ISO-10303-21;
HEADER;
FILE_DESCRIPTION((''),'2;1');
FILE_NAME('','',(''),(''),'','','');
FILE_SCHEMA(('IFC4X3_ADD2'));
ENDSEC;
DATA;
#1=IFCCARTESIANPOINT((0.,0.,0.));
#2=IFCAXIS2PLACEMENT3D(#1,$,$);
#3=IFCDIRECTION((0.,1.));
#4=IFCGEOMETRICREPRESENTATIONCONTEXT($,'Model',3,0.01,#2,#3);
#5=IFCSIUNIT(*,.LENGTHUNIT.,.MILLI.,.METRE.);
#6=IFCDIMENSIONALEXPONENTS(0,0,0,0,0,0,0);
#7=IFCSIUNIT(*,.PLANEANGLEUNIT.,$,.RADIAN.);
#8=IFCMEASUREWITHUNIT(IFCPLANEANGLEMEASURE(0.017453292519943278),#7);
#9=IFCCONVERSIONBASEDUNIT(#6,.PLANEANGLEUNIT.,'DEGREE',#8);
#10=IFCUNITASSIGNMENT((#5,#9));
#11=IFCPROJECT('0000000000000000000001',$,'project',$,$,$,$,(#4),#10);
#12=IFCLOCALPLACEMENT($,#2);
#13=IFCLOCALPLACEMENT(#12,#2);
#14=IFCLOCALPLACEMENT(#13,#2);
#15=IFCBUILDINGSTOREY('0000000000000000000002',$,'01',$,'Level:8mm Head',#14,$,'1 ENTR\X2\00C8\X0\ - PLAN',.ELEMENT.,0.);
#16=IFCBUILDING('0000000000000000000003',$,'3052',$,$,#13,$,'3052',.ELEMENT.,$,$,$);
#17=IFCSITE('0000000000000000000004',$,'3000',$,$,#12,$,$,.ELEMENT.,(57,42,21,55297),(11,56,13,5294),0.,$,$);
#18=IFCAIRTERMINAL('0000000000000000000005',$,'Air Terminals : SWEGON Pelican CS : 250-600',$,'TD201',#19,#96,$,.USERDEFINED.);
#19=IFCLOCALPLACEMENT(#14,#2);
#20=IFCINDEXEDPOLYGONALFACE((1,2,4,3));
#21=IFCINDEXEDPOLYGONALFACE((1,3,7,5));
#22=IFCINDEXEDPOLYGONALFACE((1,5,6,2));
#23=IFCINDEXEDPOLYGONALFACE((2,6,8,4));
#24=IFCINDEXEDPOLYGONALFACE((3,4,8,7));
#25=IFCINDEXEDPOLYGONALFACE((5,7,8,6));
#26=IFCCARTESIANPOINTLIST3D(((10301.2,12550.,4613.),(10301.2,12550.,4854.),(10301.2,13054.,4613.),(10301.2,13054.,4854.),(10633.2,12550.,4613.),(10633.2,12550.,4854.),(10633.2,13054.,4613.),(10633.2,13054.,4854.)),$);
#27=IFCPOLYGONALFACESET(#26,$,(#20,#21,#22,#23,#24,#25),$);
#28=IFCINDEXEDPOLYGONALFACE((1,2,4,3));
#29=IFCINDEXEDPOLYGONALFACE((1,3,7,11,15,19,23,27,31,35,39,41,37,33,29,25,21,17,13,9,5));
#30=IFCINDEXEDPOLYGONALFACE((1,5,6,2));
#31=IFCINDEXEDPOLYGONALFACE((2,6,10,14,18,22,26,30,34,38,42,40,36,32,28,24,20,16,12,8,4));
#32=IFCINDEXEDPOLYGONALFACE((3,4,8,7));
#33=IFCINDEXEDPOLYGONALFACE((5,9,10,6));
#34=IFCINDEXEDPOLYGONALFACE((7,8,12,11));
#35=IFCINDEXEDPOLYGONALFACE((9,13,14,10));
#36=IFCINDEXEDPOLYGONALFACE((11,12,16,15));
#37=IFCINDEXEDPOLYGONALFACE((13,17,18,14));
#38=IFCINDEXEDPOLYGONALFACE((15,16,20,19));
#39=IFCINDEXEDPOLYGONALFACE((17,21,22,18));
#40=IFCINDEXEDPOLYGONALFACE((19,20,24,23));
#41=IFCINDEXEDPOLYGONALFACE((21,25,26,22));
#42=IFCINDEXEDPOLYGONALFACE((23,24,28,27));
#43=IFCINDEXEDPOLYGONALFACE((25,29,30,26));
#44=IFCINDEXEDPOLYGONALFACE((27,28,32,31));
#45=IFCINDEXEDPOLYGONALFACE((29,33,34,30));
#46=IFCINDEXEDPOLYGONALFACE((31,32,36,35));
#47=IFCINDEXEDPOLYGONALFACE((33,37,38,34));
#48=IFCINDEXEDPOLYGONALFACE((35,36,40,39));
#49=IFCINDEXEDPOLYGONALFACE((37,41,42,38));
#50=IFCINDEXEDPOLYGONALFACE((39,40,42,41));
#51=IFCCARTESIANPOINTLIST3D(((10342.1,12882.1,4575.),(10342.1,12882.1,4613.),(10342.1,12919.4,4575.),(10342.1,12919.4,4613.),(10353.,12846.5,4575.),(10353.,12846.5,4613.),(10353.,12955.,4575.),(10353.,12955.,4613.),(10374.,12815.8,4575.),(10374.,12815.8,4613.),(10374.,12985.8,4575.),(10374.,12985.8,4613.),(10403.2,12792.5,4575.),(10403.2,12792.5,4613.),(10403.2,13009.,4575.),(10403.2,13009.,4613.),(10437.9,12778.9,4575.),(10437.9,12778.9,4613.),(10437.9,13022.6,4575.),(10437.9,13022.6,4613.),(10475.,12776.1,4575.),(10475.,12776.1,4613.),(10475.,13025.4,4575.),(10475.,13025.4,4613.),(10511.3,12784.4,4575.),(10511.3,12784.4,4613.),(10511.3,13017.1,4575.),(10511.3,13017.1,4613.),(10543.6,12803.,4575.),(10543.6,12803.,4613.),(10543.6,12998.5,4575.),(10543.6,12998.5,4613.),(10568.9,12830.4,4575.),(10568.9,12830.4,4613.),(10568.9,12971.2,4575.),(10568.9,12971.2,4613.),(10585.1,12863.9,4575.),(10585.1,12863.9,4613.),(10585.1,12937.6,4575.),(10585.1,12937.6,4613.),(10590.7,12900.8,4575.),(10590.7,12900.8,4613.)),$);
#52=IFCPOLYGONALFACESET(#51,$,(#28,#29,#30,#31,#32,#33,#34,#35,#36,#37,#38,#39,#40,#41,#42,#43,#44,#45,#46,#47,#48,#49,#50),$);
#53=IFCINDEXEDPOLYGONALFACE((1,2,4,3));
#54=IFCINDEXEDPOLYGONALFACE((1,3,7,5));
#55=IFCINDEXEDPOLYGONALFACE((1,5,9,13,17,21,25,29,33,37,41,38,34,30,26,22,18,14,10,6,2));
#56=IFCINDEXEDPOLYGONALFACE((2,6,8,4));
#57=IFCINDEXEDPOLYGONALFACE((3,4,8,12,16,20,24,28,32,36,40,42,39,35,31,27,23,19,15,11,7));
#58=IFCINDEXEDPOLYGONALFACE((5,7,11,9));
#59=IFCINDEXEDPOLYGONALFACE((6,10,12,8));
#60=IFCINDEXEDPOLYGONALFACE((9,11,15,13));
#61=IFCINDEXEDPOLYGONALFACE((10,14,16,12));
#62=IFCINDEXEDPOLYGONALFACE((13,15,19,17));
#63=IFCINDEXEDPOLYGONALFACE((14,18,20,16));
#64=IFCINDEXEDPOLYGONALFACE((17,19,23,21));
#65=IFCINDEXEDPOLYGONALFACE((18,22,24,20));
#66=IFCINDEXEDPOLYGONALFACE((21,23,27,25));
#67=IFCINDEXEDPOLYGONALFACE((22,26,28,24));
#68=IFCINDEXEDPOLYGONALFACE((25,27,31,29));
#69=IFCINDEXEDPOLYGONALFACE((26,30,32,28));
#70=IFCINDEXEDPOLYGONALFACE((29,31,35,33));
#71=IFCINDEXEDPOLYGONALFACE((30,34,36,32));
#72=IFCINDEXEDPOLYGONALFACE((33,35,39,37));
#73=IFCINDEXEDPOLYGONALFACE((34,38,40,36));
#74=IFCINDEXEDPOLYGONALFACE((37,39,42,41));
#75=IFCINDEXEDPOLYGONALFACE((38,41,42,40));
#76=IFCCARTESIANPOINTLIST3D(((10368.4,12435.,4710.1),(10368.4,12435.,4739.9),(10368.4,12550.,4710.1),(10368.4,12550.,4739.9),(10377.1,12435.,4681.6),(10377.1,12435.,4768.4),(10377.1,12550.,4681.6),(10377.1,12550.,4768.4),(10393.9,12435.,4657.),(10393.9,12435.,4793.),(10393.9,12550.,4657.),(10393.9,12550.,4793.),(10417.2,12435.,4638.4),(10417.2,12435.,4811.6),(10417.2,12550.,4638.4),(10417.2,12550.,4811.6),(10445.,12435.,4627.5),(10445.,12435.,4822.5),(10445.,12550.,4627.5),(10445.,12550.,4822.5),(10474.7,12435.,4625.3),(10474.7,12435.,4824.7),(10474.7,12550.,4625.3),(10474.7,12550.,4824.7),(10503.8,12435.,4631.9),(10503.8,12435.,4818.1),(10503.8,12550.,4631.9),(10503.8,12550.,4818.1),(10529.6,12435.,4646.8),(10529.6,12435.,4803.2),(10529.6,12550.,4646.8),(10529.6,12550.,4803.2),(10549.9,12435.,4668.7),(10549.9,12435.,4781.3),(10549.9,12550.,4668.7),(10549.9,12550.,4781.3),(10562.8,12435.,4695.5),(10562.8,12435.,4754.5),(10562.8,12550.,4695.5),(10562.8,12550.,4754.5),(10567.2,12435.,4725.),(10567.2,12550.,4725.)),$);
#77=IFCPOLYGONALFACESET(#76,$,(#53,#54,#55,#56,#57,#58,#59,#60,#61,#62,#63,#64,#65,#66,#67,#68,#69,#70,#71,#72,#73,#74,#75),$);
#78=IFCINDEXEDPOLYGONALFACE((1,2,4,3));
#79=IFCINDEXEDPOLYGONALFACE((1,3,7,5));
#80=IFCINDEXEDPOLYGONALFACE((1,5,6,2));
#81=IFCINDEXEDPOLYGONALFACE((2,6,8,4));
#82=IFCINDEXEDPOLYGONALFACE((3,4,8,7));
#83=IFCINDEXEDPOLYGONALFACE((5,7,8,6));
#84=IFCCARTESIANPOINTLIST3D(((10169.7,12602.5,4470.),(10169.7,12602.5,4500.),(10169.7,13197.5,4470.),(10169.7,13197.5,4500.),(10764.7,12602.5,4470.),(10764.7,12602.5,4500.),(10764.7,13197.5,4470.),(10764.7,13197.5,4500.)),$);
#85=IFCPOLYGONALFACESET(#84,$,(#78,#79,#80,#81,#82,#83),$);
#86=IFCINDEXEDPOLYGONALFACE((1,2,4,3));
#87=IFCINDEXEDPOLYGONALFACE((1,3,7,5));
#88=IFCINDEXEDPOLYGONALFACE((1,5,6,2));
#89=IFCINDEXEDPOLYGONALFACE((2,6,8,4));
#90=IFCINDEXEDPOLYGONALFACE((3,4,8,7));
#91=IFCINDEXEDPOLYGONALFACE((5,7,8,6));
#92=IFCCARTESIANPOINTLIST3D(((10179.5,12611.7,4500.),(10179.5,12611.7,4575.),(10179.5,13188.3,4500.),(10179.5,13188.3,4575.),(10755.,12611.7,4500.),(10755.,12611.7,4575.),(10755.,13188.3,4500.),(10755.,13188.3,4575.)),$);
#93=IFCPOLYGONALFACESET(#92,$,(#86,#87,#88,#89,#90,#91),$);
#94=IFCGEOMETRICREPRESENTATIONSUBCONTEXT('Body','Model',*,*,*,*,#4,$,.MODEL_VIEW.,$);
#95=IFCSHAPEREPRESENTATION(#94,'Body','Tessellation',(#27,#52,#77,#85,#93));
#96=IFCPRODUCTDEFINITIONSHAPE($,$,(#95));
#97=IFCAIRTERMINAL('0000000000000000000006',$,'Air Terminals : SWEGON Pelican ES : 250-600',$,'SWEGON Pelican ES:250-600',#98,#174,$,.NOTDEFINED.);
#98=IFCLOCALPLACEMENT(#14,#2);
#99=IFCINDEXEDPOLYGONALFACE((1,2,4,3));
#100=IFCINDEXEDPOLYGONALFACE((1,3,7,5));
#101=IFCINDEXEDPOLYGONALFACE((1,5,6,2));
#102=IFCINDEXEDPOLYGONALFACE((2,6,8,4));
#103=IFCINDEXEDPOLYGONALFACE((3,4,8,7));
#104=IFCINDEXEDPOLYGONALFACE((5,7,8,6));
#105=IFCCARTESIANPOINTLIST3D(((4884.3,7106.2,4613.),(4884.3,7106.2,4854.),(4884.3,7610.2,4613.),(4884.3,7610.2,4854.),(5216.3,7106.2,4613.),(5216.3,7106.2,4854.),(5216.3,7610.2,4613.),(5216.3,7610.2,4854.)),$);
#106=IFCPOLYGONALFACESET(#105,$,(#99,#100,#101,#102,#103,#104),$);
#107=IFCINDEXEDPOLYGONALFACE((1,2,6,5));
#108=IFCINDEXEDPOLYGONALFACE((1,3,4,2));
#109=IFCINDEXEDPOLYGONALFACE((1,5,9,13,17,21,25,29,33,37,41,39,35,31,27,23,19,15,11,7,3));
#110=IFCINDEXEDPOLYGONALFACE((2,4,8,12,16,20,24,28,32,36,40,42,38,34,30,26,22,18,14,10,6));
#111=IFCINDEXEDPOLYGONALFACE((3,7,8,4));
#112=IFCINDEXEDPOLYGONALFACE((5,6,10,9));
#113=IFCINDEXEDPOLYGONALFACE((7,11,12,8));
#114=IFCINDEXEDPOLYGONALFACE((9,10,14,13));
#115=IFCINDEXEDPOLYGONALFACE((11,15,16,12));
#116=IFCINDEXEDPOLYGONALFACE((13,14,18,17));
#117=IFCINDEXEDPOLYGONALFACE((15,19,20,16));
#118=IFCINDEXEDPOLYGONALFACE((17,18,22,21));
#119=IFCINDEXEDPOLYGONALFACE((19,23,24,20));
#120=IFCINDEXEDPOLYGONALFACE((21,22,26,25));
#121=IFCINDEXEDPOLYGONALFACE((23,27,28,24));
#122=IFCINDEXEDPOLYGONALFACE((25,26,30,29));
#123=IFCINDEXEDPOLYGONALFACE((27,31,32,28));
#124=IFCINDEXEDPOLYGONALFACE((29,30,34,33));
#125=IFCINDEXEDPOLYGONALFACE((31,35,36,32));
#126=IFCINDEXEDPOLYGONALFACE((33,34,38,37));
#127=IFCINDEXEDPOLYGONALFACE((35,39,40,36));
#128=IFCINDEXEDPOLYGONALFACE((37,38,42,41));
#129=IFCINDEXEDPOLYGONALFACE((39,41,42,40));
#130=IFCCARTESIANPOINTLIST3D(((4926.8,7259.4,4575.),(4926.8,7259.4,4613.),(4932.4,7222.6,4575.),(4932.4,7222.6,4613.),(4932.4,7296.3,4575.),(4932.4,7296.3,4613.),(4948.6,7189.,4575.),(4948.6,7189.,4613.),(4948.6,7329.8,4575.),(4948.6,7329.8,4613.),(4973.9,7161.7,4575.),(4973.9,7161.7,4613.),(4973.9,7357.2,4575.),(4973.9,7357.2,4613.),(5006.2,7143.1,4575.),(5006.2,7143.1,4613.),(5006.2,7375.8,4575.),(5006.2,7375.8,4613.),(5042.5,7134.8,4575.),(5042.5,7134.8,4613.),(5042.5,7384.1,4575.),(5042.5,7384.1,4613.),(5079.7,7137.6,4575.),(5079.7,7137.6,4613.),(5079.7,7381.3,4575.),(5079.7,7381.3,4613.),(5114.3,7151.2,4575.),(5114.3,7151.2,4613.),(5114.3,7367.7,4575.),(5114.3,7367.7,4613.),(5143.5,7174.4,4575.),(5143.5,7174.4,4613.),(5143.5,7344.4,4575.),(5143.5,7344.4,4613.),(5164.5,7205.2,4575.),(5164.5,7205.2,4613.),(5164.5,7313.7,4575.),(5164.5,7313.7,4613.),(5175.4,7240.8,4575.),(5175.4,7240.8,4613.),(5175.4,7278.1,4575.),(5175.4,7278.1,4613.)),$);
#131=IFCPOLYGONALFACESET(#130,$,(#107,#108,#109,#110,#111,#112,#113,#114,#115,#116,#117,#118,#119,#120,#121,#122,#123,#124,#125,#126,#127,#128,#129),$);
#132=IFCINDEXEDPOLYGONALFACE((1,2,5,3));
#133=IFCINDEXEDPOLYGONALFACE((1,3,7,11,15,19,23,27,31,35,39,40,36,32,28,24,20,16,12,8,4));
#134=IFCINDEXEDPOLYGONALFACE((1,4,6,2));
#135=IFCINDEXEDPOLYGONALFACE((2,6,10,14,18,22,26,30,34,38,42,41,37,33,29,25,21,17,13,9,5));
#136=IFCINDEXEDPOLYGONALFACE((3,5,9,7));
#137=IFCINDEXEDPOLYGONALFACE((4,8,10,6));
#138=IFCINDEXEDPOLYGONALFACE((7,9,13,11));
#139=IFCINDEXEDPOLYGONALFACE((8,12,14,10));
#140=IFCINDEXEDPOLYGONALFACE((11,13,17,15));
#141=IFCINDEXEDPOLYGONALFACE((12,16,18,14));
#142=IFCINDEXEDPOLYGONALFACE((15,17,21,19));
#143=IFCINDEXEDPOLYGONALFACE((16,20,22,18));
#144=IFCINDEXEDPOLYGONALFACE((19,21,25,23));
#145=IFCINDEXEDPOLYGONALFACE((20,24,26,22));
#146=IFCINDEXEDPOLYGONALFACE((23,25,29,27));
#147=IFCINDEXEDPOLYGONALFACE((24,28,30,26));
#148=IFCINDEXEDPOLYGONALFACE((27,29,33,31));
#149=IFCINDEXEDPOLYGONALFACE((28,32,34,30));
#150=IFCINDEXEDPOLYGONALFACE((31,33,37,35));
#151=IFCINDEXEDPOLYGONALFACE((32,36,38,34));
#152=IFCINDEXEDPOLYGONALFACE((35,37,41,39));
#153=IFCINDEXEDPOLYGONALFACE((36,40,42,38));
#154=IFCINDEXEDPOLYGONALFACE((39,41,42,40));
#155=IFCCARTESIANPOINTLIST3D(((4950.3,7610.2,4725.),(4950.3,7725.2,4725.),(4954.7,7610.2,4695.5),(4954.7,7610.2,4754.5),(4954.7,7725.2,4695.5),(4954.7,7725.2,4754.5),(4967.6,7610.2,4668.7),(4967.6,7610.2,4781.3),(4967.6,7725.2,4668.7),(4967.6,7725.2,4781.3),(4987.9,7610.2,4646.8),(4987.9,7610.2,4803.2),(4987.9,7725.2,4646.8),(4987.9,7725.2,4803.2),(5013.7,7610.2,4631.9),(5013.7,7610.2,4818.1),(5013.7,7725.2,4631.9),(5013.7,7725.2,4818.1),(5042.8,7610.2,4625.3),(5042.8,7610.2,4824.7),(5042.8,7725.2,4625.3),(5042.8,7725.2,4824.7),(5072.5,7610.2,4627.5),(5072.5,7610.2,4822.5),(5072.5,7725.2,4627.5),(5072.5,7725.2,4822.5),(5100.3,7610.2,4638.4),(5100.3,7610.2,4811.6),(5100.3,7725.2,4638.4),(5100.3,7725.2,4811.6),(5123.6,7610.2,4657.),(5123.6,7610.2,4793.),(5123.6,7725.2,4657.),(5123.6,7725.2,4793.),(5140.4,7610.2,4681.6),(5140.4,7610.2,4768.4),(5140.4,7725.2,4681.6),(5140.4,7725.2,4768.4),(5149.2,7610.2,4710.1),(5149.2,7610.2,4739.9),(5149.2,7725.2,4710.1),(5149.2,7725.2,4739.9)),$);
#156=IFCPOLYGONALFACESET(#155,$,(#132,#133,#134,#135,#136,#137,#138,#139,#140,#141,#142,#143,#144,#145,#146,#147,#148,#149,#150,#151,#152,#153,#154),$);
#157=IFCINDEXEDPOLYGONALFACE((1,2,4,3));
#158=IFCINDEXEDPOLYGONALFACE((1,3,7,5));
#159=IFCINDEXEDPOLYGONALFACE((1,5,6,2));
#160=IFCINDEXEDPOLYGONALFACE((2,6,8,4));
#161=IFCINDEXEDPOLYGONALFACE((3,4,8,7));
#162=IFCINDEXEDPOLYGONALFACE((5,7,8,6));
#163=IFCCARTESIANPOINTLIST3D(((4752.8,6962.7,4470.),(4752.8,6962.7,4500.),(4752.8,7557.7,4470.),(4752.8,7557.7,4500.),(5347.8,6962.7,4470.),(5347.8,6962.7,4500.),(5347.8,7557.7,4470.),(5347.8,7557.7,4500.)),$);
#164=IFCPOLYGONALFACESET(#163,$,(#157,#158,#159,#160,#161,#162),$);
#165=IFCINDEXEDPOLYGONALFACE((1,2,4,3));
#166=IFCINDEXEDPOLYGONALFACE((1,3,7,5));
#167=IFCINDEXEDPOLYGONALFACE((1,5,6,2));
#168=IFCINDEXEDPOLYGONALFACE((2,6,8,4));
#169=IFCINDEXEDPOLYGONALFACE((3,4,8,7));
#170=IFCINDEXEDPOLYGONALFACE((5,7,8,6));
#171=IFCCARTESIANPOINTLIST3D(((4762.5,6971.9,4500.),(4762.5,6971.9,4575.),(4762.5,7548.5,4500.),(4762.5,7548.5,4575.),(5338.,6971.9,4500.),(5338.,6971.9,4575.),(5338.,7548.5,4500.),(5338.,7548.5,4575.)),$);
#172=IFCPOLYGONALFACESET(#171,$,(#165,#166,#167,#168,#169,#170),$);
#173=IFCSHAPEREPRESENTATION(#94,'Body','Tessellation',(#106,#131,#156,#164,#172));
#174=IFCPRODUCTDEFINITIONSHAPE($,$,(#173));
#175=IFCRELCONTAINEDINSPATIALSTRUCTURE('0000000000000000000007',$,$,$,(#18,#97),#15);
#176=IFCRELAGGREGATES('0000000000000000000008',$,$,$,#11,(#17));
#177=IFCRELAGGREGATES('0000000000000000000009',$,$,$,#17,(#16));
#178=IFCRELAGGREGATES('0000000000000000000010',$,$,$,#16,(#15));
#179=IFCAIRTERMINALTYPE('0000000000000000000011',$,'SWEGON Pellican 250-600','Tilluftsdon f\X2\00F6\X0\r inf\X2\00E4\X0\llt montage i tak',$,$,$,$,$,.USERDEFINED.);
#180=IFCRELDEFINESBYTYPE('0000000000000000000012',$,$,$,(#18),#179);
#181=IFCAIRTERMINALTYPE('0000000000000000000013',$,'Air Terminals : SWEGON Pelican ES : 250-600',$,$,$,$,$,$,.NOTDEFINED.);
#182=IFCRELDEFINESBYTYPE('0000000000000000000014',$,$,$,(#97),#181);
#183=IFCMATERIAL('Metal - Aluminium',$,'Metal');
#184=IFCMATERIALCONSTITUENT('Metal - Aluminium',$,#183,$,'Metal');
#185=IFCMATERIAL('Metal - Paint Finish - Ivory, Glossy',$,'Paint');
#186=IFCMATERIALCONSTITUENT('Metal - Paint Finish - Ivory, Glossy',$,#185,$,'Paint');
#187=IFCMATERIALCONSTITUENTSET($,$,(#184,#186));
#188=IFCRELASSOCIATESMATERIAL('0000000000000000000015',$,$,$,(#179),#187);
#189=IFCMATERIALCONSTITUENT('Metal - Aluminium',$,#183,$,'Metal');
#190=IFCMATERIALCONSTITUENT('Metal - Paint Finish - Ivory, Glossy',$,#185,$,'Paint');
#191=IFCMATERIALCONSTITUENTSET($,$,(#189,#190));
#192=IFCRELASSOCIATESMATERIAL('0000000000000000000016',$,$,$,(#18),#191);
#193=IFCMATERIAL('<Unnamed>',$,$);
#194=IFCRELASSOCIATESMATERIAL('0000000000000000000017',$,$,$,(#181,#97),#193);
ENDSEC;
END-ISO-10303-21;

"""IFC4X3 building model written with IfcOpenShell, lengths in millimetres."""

from ifc_helpers import new_model, entity, si_unit, converted_unit, direction, frame, frame_2d, origin, origin_2d_with_axis, place, context, subcontext, project, spatial, rectangle, circle, extrude, source, transform, mapped, material, constituent, constituent_set, type_object, type_shapes, element, save


model = new_model("IFC4X3")

# Units and contexts
model_context = context("Model", 3, precision=0.01, world=origin(), true_north=direction((0.0, 1.0)))
body_context = subcontext(model_context, "Body", "Model", "MODEL_VIEW")
ifc_project = project(units=[si_unit("LENGTHUNIT", "METRE", prefix="MILLI"), converted_unit("PLANEANGLEUNIT", "DEGREE", entity("IfcPlaneAngleMeasure", 0.017453292519943278), si_unit("PLANEANGLEUNIT", "RADIAN"), dimensions=[0, 0, 0, 0, 0, 0, 0])], contexts=[model_context])

# Site, building, storey
site_placement = place(None, origin())
site = spatial("IfcSite", under=ifc_project, at=site_placement, Name="3000", CompositionType="ELEMENT", RefLatitude=(57, 42, 21, 55297), RefLongitude=(11, 56, 13, 5294), RefElevation=0.0)
building_placement = place(site_placement, origin())
building = spatial("IfcBuilding", under=site, at=building_placement, Name="3052", LongName="3052", CompositionType="ELEMENT")
storey_placement = place(building_placement, origin())
storey = spatial("IfcBuildingStorey", under=building, at=storey_placement, Name="01", ObjectType="Level:8mm Head", LongName="1 ENTRÈ - PLAN", CompositionType="ELEMENT", Elevation=0.0)

# Shared definitions
ifc_material_1 = material(Name="<Unnamed>")

# Air terminals
ifc_material_2 = material(Name="Metal - Aluminium", Category="Metal")
ifc_constituent_1 = constituent(ifc_material_2, Name="Metal - Aluminium", Category="Metal")
ifc_material_3 = material(Name="Metal - Paint Finish - Ivory, Glossy", Category="Paint")
ifc_constituent_2 = constituent(ifc_material_3, Name="Metal - Paint Finish - Ivory, Glossy", Category="Paint")
ifc_constituent_set_1 = constituent_set(constituents=[ifc_constituent_1, ifc_constituent_2])
ifc_constituent_3 = constituent(ifc_material_2, Name="Metal - Aluminium", Category="Metal")
ifc_constituent_4 = constituent(ifc_material_3, Name="Metal - Paint Finish - Ivory, Glossy", Category="Paint")
ifc_constituent_set_2 = constituent_set(constituents=[ifc_constituent_3, ifc_constituent_4])
air_terminal_type_1 = type_object("IfcAirTerminalType", Name="SWEGON Pellican 250-600", Description="Tilluftsdon för infällt montage i tak", PredefinedType="USERDEFINED", material=ifc_constituent_set_2)
shared_shape_1 = source(origin(), body_context, "Body", "SweptSolid", [
    extrude(rectangle(XDim=332.0, YDim=504.0, at=origin_2d_with_axis()), frame((0.0, 98.0, -354.0), z_axis=(0.0, 0.0, 1.0), x_axis=(-1.0, 0.0, 0.0)), (0.0, 0.0, 1.0), 241.0),
    extrude(circle(Radius=125.0, at=frame_2d((0.0, 0.0), x_axis=(1.0, 0.0))), frame((-1.6, -0.8, -113.0)), (0.0, 0.0, 1.0), 38.0),
    extrude(circle(Radius=100.0, at=frame_2d((0.0, 0.0), x_axis=(1.0, 0.0))), frame((0.0, 350.0, -225.0), z_axis=(0.0, 1.0, 0.0), x_axis=(1.0, 0.0, 0.0)), (0.0, 0.0, 1.0), 115.0),
    extrude(rectangle(XDim=595.0, YDim=595.0, at=frame_2d((0.0, 0.0), x_axis=(1.0, 0.0))), frame((0.0, 0.0, 0.0), z_axis=(0.0, 0.0, 1.0), x_axis=(-1.0, 0.0, 0.0)), (0.0, 0.0, 1.0), 30.0),
    extrude(rectangle(XDim=575.5, YDim=576.5, at=origin_2d_with_axis()), frame((0.0, 0.0, -75.0), z_axis=(0.0, 0.0, 1.0), x_axis=(-1.0, 0.0, 0.0)), (0.0, 0.0, 1.0), 75.0),
])
type_shapes(air_terminal_type_1, [shared_shape_1])
air_terminal_1_placement = place(storey_placement, frame((10467.2, 12900.0, 4500.0), z_axis=(0.0, 0.0, -1.0), x_axis=(1.0, 0.0, 0.0)))
element("IfcAirTerminal", 1, at=air_terminal_1_placement, inside=storey, type_object=air_terminal_type_1, material=ifc_constituent_set_1, Name="Air Terminals : SWEGON Pelican CS : 250-600", ObjectType="TD201", PredefinedType="USERDEFINED", context=body_context, shape_type="MappedRepresentation", body=[
    mapped(shared_shape_1, transform((0.0, 0.0, 0.0), scale=1.0)),
])
air_terminal_type_2 = type_object("IfcAirTerminalType", Name="Air Terminals : SWEGON Pelican ES : 250-600", PredefinedType="NOTDEFINED", material=ifc_material_1)
shared_shape_2 = source(origin(), body_context, "Body", "SweptSolid", [
    extrude(rectangle(XDim=332.0, YDim=504.0, at=origin_2d_with_axis()), frame((0.0, 98.0, -354.0), z_axis=(0.0, 0.0, 1.0), x_axis=(-1.0, 0.0, 0.0)), (0.0, 0.0, 1.0), 241.0),
    extrude(circle(Radius=125.0, at=frame_2d((0.0, 0.0), x_axis=(1.0, 0.0))), frame((-1.6, -0.8, -113.0)), (0.0, 0.0, 1.0), 38.0),
    extrude(circle(Radius=100.0, at=frame_2d((0.0, 0.0), x_axis=(1.0, 0.0))), frame((0.0, 350.0, -225.0), z_axis=(0.0, 1.0, 0.0), x_axis=(1.0, 0.0, 0.0)), (0.0, 0.0, 1.0), 115.0),
    extrude(rectangle(XDim=595.0, YDim=595.0, at=frame_2d((0.0, 0.0), x_axis=(1.0, 0.0))), frame((0.0, 0.0, 0.0), z_axis=(0.0, 0.0, 1.0), x_axis=(-1.0, 0.0, 0.0)), (0.0, 0.0, 1.0), 30.0),
    extrude(rectangle(XDim=575.5, YDim=576.5, at=origin_2d_with_axis()), frame((0.0, 0.0, -75.0), z_axis=(0.0, 0.0, 1.0), x_axis=(-1.0, 0.0, 0.0)), (0.0, 0.0, 1.0), 75.0),
])
type_shapes(air_terminal_type_2, [shared_shape_2])
air_terminal_2_placement = place(storey_placement, frame((5050.3, 7260.2, 4500.0), z_axis=(0.0, 0.0, -1.0), x_axis=(-1.0, 0.0, 0.0)))
element("IfcAirTerminal", 2, at=air_terminal_2_placement, inside=storey, type_object=air_terminal_type_2, material=ifc_material_1, Name="Air Terminals : SWEGON Pelican ES : 250-600", ObjectType="SWEGON Pelican ES:250-600", PredefinedType="NOTDEFINED", context=body_context, shape_type="MappedRepresentation", body=[
    mapped(shared_shape_2, transform((0.0, 0.0, 0.0), scale=1.0)),
])

save(model, "model.ifc")
